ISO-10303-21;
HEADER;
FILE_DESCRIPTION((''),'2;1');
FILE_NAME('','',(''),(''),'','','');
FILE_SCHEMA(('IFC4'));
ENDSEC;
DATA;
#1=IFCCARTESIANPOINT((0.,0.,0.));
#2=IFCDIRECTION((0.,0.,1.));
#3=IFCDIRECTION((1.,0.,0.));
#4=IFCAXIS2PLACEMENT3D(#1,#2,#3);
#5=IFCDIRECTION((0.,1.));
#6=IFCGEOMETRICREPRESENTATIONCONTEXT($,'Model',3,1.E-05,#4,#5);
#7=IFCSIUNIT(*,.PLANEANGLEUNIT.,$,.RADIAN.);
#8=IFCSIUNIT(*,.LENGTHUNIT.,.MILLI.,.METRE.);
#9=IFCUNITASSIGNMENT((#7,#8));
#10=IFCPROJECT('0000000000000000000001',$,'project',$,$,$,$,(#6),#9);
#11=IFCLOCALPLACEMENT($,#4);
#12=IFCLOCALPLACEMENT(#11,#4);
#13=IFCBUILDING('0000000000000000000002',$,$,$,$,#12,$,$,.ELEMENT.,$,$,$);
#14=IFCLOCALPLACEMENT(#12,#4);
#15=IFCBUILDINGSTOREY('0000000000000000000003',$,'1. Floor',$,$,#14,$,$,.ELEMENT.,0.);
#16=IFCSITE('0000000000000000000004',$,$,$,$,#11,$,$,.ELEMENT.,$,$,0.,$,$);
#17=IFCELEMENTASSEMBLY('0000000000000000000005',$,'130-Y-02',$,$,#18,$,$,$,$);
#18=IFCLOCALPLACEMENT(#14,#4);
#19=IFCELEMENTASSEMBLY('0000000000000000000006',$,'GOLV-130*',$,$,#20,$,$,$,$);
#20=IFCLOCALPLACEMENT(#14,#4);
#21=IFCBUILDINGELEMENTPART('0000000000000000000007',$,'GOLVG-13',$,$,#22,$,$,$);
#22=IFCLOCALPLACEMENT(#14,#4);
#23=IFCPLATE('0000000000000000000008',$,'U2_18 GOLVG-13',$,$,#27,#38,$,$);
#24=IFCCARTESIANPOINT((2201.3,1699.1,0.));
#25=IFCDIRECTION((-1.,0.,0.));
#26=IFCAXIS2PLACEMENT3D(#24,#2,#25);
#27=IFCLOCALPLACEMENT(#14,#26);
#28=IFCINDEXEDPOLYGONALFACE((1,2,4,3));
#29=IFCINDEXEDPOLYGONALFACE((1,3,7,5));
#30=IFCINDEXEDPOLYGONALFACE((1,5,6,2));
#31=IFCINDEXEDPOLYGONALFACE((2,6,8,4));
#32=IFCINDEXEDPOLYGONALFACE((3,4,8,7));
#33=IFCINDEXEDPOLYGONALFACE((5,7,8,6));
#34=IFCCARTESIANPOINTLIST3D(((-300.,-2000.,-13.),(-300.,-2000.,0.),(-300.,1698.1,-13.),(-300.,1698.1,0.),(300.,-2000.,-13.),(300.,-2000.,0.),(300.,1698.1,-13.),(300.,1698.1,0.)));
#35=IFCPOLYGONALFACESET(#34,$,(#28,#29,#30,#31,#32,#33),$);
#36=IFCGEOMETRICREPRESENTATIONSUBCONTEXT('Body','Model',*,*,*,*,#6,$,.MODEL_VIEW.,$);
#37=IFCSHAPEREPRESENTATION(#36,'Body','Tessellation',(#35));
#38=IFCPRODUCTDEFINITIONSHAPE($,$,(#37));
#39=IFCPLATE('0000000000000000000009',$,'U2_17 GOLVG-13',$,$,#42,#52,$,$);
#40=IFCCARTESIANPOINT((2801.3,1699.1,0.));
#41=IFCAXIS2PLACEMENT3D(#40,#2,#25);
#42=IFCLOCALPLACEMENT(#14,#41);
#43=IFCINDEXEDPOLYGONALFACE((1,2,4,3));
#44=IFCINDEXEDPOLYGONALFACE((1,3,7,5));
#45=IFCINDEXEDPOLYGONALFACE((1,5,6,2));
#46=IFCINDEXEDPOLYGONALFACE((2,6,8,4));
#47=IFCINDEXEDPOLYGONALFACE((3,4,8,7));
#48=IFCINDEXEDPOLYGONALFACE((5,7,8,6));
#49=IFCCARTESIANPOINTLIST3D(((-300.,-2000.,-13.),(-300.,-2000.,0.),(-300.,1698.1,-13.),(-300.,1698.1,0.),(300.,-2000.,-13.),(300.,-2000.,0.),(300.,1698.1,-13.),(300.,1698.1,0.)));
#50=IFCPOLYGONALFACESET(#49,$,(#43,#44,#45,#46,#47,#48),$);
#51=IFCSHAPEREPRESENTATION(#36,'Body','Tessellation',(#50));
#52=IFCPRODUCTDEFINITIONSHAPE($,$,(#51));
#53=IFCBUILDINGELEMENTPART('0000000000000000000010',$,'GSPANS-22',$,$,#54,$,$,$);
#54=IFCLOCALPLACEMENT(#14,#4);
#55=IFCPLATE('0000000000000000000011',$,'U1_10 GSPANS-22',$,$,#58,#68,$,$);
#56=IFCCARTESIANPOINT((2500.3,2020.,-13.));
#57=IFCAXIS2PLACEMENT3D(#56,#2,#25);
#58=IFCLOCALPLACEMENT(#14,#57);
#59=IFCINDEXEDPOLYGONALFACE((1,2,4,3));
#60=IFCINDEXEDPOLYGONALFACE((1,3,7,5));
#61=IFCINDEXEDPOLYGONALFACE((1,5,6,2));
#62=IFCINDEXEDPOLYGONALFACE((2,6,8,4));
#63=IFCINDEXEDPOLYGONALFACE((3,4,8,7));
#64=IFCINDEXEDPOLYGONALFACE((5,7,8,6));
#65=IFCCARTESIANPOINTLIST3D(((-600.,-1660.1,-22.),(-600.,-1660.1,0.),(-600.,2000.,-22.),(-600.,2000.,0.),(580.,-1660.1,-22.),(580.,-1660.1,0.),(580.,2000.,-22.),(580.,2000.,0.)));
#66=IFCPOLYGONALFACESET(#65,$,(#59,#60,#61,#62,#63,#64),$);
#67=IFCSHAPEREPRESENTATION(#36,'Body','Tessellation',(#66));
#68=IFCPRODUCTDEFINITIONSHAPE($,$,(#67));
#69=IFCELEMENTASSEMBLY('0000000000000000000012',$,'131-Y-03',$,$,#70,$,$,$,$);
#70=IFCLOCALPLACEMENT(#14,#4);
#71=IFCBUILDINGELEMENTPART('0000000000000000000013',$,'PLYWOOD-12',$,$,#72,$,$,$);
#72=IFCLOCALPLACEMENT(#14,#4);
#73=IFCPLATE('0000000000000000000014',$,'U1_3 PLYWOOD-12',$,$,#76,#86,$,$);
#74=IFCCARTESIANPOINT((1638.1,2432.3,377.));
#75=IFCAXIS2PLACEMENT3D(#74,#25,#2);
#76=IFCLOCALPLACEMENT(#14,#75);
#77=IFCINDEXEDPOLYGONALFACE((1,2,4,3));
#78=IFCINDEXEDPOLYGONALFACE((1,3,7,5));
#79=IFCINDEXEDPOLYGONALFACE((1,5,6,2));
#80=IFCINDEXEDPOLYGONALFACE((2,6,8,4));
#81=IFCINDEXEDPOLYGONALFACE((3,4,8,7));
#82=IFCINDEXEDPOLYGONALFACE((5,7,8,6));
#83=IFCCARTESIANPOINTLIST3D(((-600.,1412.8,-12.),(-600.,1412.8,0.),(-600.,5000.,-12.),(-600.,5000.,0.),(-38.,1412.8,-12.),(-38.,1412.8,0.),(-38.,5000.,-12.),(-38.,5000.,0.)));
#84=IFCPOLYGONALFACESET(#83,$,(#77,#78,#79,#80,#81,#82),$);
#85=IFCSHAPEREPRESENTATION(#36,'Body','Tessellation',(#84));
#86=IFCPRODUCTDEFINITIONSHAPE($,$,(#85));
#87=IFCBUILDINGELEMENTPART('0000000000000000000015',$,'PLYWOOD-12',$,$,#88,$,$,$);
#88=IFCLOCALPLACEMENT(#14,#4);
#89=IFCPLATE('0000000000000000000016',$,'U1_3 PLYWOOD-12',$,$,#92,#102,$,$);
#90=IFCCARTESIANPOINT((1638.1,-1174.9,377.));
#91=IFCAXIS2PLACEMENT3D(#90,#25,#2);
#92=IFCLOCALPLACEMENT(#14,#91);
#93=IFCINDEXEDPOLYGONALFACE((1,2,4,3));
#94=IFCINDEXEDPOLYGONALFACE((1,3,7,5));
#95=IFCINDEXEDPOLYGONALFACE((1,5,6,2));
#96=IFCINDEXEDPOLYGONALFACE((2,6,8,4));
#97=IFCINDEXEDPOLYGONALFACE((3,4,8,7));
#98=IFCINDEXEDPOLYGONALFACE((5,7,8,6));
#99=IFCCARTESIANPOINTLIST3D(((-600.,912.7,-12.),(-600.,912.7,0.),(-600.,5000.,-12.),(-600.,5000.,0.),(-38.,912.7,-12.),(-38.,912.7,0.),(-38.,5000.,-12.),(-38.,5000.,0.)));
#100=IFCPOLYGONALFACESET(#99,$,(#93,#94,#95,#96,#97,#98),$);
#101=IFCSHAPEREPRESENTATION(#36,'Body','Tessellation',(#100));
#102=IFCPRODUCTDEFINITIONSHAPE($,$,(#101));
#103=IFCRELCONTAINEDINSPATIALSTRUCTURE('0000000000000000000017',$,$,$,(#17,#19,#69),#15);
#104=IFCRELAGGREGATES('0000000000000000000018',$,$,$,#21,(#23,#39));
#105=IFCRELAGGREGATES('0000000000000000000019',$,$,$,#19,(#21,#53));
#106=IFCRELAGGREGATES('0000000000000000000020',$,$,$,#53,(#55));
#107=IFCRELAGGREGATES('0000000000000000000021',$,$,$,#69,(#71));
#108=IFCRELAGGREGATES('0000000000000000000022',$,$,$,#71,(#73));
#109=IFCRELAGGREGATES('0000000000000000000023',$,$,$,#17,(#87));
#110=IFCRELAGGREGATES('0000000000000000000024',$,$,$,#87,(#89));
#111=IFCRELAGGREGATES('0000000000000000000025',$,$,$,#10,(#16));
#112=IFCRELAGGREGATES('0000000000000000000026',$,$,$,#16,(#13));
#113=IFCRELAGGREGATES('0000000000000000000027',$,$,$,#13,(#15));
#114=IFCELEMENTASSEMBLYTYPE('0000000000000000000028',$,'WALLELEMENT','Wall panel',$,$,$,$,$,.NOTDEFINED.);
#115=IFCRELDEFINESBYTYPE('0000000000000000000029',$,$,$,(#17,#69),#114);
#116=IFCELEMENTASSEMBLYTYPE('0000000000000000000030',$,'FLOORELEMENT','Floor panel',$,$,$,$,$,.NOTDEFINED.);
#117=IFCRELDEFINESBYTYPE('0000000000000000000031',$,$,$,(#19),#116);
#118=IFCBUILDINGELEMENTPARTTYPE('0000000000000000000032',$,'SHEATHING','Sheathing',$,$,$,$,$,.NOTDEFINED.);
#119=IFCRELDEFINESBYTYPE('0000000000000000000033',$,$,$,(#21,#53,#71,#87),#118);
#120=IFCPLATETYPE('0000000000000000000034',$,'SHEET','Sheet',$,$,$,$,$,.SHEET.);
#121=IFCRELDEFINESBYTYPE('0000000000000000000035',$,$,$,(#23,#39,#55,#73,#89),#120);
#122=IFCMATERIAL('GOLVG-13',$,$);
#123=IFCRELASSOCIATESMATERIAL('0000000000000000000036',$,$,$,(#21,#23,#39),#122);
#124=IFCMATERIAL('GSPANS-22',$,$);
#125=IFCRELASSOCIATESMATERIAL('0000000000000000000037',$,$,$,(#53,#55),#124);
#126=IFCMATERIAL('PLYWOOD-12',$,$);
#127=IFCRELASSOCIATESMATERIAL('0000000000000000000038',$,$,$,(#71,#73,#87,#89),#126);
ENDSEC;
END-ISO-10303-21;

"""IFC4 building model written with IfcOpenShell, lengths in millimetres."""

from ifc_helpers import new_model, si_unit, direction, frame, origin_with_axes, origin_2d_with_axis, place, context, subcontext, project, spatial, rectangle, extrude, material, type_object, element, aggregate, save


model = new_model("IFC4")

# Units and contexts
model_context = context("Model", 3, precision=1e-05, world=origin_with_axes(), true_north=direction((0.0, 1.0)))
body_context = subcontext(model_context, "Body", "Model", "MODEL_VIEW")
ifc_project = project(units=[si_unit("PLANEANGLEUNIT", "RADIAN"), si_unit("LENGTHUNIT", "METRE", prefix="MILLI")], contexts=[model_context])

# Site, building, storey
site_placement = place(None, origin_with_axes())
site = spatial("IfcSite", under=ifc_project, at=site_placement, CompositionType="ELEMENT", RefElevation=0.0)
building_placement = place(site_placement, origin_with_axes())
building = spatial("IfcBuilding", under=site, at=building_placement, CompositionType="ELEMENT")
storey_placement = place(building_placement, origin_with_axes())
storey = spatial("IfcBuildingStorey", under=building, at=storey_placement, Name="1. Floor", CompositionType="ELEMENT", Elevation=0.0)

# Element assembly
element_assembly_type_1 = type_object("IfcElementAssemblyType", Name="WALLELEMENT", Description="Wall panel", PredefinedType="NOTDEFINED")
assembly_1_placement = place(storey_placement, origin_with_axes())
assembly_1 = element("IfcElementAssembly", 1, at=assembly_1_placement, inside=storey, type_object=element_assembly_type_1, Name="130-Y-02")

# Element assembly, building element parts, plates
element_assembly_type_2 = type_object("IfcElementAssemblyType", Name="FLOORELEMENT", Description="Floor panel", PredefinedType="NOTDEFINED")
assembly_2_placement = place(storey_placement, origin_with_axes())
assembly_2 = element("IfcElementAssembly", 2, at=assembly_2_placement, inside=storey, type_object=element_assembly_type_2, Name="GOLV-130*")
ifc_material_1 = material(Name="GOLVG-13")
building_element_part_type_1 = type_object("IfcBuildingElementPartType", Name="SHEATHING", Description="Sheathing", PredefinedType="NOTDEFINED")
plate_type = type_object("IfcPlateType", Name="SHEET", Description="Sheet", PredefinedType="SHEET")
building_element_part_1_placement = place(storey_placement, origin_with_axes())
building_element_part_1 = element("IfcBuildingElementPart", 3, at=building_element_part_1_placement, type_object=building_element_part_type_1, material=ifc_material_1, Name="GOLVG-13")
plate_1_placement = place(storey_placement, frame((2201.3, 1699.1, 0.0), z_axis=(0.0, 0.0, 1.0), x_axis=(-1.0, 0.0, 0.0)))
plate_1 = element("IfcPlate", 4, at=plate_1_placement, type_object=plate_type, material=ifc_material_1, Name="U2_18 GOLVG-13", context=body_context, shape_type="SweptSolid", body=[
    extrude(rectangle(XDim=13.0, YDim=600.0, at=origin_2d_with_axis()), frame((0.0, -2000.0, -6.5), z_axis=(0.0, 1.0, 0.0), x_axis=(0.0, 0.0, 1.0)), (0.0, 0.0, 1.0), 3698.1),
])
plate_2_placement = place(storey_placement, frame((2801.3, 1699.1, 0.0), z_axis=(0.0, 0.0, 1.0), x_axis=(-1.0, 0.0, 0.0)))
plate_2 = element("IfcPlate", 5, at=plate_2_placement, type_object=plate_type, material=ifc_material_1, Name="U2_17 GOLVG-13", context=body_context, shape_type="SweptSolid", body=[
    extrude(rectangle(XDim=13.0, YDim=600.0, at=origin_2d_with_axis()), frame((0.0, -2000.0, -6.5), z_axis=(0.0, 1.0, 0.0), x_axis=(0.0, 0.0, 1.0)), (0.0, 0.0, 1.0), 3698.1),
])
aggregate(building_element_part_1, [plate_1, plate_2])
ifc_material_2 = material(Name="GSPANS-22")
building_element_part_2_placement = place(storey_placement, origin_with_axes())
building_element_part_2 = element("IfcBuildingElementPart", 6, at=building_element_part_2_placement, type_object=building_element_part_type_1, material=ifc_material_2, Name="GSPANS-22")
aggregate(assembly_2, [building_element_part_1, building_element_part_2])
plate_3_placement = place(storey_placement, frame((2500.3, 2020.0, -13.0), z_axis=(0.0, 0.0, 1.0), x_axis=(-1.0, 0.0, 0.0)))
plate_3 = element("IfcPlate", 7, at=plate_3_placement, type_object=plate_type, material=ifc_material_2, Name="U1_10 GSPANS-22", context=body_context, shape_type="SweptSolid", body=[
    extrude(rectangle(XDim=22.0, YDim=1180.0, at=origin_2d_with_axis()), frame((-10.0, -1660.1, -11.0), z_axis=(0.0, 1.0, 0.0), x_axis=(0.0, 0.0, 1.0)), (0.0, 0.0, 1.0), 3660.1),
])
aggregate(building_element_part_2, [plate_3])

# Element assembly, building element part, plate
assembly_3_placement = place(storey_placement, origin_with_axes())
assembly_3 = element("IfcElementAssembly", 8, at=assembly_3_placement, inside=storey, type_object=element_assembly_type_1, Name="131-Y-03")
ifc_material_3 = material(Name="PLYWOOD-12")
building_element_part_3_placement = place(storey_placement, origin_with_axes())
building_element_part_3 = element("IfcBuildingElementPart", 9, at=building_element_part_3_placement, type_object=building_element_part_type_1, material=ifc_material_3, Name="PLYWOOD-12")
aggregate(assembly_3, [building_element_part_3])
plate_4_placement = place(storey_placement, frame((1638.1, 2432.3, 377.0), z_axis=(-1.0, 0.0, 0.0), x_axis=(0.0, 0.0, 1.0)))
plate_4 = element("IfcPlate", 10, at=plate_4_placement, type_object=plate_type, material=ifc_material_3, Name="U1_3 PLYWOOD-12", context=body_context, shape_type="SweptSolid", body=[
    extrude(rectangle(XDim=12.0, YDim=562.0, at=origin_2d_with_axis()), frame((-319.0, 1412.8, -6.0), z_axis=(0.0, 1.0, 0.0), x_axis=(0.0, 0.0, 1.0)), (0.0, 0.0, 1.0), 3587.2),
])
aggregate(building_element_part_3, [plate_4])

# Building element part
building_element_part_4_placement = place(storey_placement, origin_with_axes())
building_element_part_4 = element("IfcBuildingElementPart", 11, at=building_element_part_4_placement, type_object=building_element_part_type_1, material=ifc_material_3, Name="PLYWOOD-12")
aggregate(assembly_1, [building_element_part_4])

# Plate
plate_5_placement = place(storey_placement, frame((1638.1, -1174.9, 377.0), z_axis=(-1.0, 0.0, 0.0), x_axis=(0.0, 0.0, 1.0)))
plate_5 = element("IfcPlate", 12, at=plate_5_placement, type_object=plate_type, material=ifc_material_3, Name="U1_3 PLYWOOD-12", context=body_context, shape_type="SweptSolid", body=[
    extrude(rectangle(XDim=12.0, YDim=562.0, at=origin_2d_with_axis()), frame((-319.0, 912.7, -6.0), z_axis=(0.0, 1.0, 0.0), x_axis=(0.0, 0.0, 1.0)), (0.0, 0.0, 1.0), 4087.3),
])
aggregate(building_element_part_4, [plate_5])

save(model, "model.ifc")
